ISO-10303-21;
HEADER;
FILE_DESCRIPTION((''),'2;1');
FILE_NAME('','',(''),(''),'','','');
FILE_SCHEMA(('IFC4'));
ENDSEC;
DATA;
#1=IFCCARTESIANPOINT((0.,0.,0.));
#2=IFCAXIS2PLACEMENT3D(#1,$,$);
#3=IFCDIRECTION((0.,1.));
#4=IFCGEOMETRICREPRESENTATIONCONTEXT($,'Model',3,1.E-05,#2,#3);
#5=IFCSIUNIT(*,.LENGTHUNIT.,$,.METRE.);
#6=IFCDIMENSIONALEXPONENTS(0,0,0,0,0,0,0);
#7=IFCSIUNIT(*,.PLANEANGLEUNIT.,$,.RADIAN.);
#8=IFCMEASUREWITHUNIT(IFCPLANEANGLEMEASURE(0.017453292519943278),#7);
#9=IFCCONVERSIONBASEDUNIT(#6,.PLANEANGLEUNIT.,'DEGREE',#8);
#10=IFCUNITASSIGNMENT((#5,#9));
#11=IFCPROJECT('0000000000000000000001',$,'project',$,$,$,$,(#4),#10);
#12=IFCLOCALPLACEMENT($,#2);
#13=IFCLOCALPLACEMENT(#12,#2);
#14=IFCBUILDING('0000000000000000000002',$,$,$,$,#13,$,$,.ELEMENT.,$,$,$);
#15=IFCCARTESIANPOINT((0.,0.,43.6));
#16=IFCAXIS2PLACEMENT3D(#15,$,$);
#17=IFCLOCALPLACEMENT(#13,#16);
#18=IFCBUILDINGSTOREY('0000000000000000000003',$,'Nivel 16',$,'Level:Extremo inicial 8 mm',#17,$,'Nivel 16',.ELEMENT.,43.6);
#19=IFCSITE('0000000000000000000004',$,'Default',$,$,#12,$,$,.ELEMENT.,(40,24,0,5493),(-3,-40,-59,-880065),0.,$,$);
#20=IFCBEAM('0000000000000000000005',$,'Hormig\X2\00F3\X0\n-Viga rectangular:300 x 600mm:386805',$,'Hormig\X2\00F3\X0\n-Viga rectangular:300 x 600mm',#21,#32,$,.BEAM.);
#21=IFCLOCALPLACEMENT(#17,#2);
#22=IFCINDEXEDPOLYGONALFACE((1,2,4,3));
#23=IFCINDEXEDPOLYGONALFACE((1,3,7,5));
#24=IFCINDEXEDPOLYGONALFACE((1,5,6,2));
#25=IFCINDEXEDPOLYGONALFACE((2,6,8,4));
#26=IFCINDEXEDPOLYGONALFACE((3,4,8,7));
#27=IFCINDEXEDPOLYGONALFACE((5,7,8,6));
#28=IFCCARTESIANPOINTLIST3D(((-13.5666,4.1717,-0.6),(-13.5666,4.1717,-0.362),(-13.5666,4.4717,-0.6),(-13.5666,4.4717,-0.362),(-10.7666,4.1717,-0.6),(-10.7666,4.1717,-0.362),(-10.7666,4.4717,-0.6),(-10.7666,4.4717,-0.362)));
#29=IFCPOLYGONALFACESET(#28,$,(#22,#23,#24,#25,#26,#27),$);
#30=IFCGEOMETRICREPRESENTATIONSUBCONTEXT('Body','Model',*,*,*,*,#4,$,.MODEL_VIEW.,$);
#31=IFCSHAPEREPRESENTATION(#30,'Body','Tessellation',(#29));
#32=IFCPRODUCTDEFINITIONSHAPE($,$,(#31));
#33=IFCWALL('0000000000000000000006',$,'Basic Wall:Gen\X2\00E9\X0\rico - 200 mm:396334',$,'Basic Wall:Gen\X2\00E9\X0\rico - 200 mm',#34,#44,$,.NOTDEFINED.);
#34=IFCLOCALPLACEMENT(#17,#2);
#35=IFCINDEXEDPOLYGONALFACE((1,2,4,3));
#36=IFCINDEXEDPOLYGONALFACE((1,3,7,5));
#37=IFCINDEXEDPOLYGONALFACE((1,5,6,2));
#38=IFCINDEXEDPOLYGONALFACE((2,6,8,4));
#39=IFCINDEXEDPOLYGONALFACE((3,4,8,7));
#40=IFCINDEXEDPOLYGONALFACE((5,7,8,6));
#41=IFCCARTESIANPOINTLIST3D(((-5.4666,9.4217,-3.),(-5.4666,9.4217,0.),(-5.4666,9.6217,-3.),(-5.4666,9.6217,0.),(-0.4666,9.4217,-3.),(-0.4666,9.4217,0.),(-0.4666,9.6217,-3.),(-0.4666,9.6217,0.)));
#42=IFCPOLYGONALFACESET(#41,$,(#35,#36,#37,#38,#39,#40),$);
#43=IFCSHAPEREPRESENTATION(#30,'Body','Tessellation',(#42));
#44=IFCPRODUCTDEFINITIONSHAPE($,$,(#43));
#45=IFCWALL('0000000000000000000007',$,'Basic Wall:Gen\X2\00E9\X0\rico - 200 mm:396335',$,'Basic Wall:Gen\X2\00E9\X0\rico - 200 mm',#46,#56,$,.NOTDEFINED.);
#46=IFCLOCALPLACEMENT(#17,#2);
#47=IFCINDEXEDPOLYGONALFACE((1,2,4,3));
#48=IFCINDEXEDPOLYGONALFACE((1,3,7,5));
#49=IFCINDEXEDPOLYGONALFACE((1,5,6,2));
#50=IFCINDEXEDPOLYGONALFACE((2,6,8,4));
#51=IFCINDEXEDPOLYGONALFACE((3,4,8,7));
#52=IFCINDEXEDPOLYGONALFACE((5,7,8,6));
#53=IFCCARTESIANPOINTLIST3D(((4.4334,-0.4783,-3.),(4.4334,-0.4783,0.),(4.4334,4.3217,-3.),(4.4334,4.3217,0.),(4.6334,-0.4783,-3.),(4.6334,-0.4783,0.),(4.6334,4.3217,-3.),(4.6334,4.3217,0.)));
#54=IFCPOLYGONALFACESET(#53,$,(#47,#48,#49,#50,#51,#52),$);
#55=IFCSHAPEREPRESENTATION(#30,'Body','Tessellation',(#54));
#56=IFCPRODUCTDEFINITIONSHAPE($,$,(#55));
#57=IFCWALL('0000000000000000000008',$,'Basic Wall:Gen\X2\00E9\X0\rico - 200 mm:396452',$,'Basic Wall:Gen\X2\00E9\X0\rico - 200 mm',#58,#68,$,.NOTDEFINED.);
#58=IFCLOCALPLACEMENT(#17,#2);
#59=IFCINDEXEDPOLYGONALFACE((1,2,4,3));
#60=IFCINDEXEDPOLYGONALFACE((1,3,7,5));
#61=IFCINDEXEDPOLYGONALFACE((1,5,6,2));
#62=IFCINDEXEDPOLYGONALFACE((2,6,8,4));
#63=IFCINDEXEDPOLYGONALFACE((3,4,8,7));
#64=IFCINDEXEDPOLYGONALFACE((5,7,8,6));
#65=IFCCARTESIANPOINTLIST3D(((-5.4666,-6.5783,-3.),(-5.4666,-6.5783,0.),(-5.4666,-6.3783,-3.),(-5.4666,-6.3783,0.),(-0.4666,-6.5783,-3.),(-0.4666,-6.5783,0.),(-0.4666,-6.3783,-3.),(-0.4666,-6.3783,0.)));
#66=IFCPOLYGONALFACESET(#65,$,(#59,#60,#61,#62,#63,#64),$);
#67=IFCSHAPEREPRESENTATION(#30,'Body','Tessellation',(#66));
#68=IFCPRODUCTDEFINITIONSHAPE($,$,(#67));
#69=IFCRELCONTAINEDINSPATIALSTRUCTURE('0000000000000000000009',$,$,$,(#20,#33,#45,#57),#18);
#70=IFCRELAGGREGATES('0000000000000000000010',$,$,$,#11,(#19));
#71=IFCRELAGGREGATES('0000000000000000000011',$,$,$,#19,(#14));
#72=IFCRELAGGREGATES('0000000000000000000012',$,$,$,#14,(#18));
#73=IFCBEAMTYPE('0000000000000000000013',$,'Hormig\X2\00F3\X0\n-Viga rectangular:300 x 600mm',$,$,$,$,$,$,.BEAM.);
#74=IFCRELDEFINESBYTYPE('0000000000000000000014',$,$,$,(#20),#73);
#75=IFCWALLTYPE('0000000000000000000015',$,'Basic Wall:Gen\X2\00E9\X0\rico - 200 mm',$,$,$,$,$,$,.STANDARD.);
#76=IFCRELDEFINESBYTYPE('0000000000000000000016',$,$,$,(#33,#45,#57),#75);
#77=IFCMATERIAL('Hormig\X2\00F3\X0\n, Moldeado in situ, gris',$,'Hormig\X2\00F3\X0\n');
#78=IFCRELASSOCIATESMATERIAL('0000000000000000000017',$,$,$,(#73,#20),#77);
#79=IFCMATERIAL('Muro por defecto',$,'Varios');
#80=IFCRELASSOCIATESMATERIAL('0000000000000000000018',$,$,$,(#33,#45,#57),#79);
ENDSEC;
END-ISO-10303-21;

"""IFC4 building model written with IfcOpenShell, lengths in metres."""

from ifc_helpers import new_model, entity, si_unit, converted_unit, direction, frame, origin, place, context, subcontext, project, spatial, indexed_curve, outline, extrude, source, transform, mapped, material, type_object, type_shapes, element, save


model = new_model("IFC4")

# Units and contexts
model_context = context("Model", 3, precision=1e-05, world=origin(), true_north=direction((0.0, 1.0)))
body_context = subcontext(model_context, "Body", "Model", "MODEL_VIEW")
ifc_project = project(units=[si_unit("LENGTHUNIT", "METRE"), converted_unit("PLANEANGLEUNIT", "DEGREE", entity("IfcPlaneAngleMeasure", 0.017453292519943278), si_unit("PLANEANGLEUNIT", "RADIAN"), dimensions=[0, 0, 0, 0, 0, 0, 0])], contexts=[model_context])

# Site, building, storey
site_placement = place(None, origin())
site = spatial("IfcSite", under=ifc_project, at=site_placement, Name="Default", CompositionType="ELEMENT", RefLatitude=(40, 24, 0, 5493), RefLongitude=(-3, -40, -59, -880065), RefElevation=0.0)
building_placement = place(site_placement, origin())
building = spatial("IfcBuilding", under=site, at=building_placement, CompositionType="ELEMENT")
storey_placement = place(building_placement, frame((0.0, 0.0, 43.6)))
storey = spatial("IfcBuildingStorey", under=building, at=storey_placement, Name="Nivel 16", ObjectType="Level:Extremo inicial 8 mm", LongName="Nivel 16", CompositionType="ELEMENT", Elevation=43.6)

# Shared definitions
ifc_material_1 = material(Name="Hormigón, Moldeado in situ, gris", Category="Hormigón")

# Beam
beam_type_1 = type_object("IfcBeamType", Name="Hormigón-Viga rectangular:300 x 600mm", PredefinedType="BEAM", material=ifc_material_1)
shared_shape_1 = source(origin(), body_context, "Body", "SweptSolid", [
    extrude(outline(indexed_curve([(-0.119, -0.15), (0.119, -0.15), (0.119, 0.15), (-0.119, 0.15), (-0.119, -0.15)], self_intersect=False)), frame((-10.7666, 4.3217, 43.119), z_axis=(-1.0, 0.0, 0.0), x_axis=(0.0, 0.0, -1.0)), (0.0, 0.0, 1.0), 2.8),
])
type_shapes(beam_type_1, [shared_shape_1])
beam_1_placement = place(storey_placement, frame((0.0, 0.0, -43.6)))
element("IfcBeam", 1, at=beam_1_placement, inside=storey, type_object=beam_type_1, material=ifc_material_1, Name="Hormigón-Viga rectangular:300 x 600mm:386805", ObjectType="Hormigón-Viga rectangular:300 x 600mm", PredefinedType="BEAM", context=body_context, shape_type="MappedRepresentation", body=[
    mapped(shared_shape_1, transform((0.0, 0.0, 0.0), scale=1.0)),
])

# Walls
ifc_material_2 = material(Name="Muro por defecto", Category="Varios")
wall_type = type_object("IfcWallType", Name="Basic Wall:Genérico - 200 mm", PredefinedType="STANDARD")
wall_1_placement = place(storey_placement, frame((-5.4666, 9.5217, -3.0)))
element("IfcWall", 2, at=wall_1_placement, inside=storey, type_object=wall_type, material=ifc_material_2, Name="Basic Wall:Genérico - 200 mm:396334", ObjectType="Basic Wall:Genérico - 200 mm", PredefinedType="NOTDEFINED", context=body_context, shape_type="SweptSolid", body=[
    extrude(outline(indexed_curve([(5.0, 0.1), (0.0, 0.1), (0.0, -0.1), (5.0, -0.1), (5.0, 0.1)], self_intersect=False)), origin(), (0.0, 0.0, 1.0), 3.0),
])
wall_2_placement = place(storey_placement, frame((4.5334, 4.3217, -3.0), z_axis=(0.0, 0.0, 1.0), x_axis=(0.0, -1.0, 0.0)))
element("IfcWall", 3, at=wall_2_placement, inside=storey, type_object=wall_type, material=ifc_material_2, Name="Basic Wall:Genérico - 200 mm:396335", ObjectType="Basic Wall:Genérico - 200 mm", PredefinedType="NOTDEFINED", context=body_context, shape_type="SweptSolid", body=[
    extrude(outline(indexed_curve([(4.8, 0.1), (0.0, 0.1), (0.0, -0.1), (4.8, -0.1), (4.8, 0.1)], self_intersect=False)), origin(), (0.0, 0.0, 1.0), 3.0),
])
wall_3_placement = place(storey_placement, frame((-5.4666, -6.4783, -3.0)))
element("IfcWall", 4, at=wall_3_placement, inside=storey, type_object=wall_type, material=ifc_material_2, Name="Basic Wall:Genérico - 200 mm:396452", ObjectType="Basic Wall:Genérico - 200 mm", PredefinedType="NOTDEFINED", context=body_context, shape_type="SweptSolid", body=[
    extrude(outline(indexed_curve([(5.0, 0.1), (0.0, 0.1), (0.0, -0.1), (5.0, -0.1), (5.0, 0.1)], self_intersect=False)), origin(), (0.0, 0.0, 1.0), 3.0),
])

save(model, "model.ifc")
